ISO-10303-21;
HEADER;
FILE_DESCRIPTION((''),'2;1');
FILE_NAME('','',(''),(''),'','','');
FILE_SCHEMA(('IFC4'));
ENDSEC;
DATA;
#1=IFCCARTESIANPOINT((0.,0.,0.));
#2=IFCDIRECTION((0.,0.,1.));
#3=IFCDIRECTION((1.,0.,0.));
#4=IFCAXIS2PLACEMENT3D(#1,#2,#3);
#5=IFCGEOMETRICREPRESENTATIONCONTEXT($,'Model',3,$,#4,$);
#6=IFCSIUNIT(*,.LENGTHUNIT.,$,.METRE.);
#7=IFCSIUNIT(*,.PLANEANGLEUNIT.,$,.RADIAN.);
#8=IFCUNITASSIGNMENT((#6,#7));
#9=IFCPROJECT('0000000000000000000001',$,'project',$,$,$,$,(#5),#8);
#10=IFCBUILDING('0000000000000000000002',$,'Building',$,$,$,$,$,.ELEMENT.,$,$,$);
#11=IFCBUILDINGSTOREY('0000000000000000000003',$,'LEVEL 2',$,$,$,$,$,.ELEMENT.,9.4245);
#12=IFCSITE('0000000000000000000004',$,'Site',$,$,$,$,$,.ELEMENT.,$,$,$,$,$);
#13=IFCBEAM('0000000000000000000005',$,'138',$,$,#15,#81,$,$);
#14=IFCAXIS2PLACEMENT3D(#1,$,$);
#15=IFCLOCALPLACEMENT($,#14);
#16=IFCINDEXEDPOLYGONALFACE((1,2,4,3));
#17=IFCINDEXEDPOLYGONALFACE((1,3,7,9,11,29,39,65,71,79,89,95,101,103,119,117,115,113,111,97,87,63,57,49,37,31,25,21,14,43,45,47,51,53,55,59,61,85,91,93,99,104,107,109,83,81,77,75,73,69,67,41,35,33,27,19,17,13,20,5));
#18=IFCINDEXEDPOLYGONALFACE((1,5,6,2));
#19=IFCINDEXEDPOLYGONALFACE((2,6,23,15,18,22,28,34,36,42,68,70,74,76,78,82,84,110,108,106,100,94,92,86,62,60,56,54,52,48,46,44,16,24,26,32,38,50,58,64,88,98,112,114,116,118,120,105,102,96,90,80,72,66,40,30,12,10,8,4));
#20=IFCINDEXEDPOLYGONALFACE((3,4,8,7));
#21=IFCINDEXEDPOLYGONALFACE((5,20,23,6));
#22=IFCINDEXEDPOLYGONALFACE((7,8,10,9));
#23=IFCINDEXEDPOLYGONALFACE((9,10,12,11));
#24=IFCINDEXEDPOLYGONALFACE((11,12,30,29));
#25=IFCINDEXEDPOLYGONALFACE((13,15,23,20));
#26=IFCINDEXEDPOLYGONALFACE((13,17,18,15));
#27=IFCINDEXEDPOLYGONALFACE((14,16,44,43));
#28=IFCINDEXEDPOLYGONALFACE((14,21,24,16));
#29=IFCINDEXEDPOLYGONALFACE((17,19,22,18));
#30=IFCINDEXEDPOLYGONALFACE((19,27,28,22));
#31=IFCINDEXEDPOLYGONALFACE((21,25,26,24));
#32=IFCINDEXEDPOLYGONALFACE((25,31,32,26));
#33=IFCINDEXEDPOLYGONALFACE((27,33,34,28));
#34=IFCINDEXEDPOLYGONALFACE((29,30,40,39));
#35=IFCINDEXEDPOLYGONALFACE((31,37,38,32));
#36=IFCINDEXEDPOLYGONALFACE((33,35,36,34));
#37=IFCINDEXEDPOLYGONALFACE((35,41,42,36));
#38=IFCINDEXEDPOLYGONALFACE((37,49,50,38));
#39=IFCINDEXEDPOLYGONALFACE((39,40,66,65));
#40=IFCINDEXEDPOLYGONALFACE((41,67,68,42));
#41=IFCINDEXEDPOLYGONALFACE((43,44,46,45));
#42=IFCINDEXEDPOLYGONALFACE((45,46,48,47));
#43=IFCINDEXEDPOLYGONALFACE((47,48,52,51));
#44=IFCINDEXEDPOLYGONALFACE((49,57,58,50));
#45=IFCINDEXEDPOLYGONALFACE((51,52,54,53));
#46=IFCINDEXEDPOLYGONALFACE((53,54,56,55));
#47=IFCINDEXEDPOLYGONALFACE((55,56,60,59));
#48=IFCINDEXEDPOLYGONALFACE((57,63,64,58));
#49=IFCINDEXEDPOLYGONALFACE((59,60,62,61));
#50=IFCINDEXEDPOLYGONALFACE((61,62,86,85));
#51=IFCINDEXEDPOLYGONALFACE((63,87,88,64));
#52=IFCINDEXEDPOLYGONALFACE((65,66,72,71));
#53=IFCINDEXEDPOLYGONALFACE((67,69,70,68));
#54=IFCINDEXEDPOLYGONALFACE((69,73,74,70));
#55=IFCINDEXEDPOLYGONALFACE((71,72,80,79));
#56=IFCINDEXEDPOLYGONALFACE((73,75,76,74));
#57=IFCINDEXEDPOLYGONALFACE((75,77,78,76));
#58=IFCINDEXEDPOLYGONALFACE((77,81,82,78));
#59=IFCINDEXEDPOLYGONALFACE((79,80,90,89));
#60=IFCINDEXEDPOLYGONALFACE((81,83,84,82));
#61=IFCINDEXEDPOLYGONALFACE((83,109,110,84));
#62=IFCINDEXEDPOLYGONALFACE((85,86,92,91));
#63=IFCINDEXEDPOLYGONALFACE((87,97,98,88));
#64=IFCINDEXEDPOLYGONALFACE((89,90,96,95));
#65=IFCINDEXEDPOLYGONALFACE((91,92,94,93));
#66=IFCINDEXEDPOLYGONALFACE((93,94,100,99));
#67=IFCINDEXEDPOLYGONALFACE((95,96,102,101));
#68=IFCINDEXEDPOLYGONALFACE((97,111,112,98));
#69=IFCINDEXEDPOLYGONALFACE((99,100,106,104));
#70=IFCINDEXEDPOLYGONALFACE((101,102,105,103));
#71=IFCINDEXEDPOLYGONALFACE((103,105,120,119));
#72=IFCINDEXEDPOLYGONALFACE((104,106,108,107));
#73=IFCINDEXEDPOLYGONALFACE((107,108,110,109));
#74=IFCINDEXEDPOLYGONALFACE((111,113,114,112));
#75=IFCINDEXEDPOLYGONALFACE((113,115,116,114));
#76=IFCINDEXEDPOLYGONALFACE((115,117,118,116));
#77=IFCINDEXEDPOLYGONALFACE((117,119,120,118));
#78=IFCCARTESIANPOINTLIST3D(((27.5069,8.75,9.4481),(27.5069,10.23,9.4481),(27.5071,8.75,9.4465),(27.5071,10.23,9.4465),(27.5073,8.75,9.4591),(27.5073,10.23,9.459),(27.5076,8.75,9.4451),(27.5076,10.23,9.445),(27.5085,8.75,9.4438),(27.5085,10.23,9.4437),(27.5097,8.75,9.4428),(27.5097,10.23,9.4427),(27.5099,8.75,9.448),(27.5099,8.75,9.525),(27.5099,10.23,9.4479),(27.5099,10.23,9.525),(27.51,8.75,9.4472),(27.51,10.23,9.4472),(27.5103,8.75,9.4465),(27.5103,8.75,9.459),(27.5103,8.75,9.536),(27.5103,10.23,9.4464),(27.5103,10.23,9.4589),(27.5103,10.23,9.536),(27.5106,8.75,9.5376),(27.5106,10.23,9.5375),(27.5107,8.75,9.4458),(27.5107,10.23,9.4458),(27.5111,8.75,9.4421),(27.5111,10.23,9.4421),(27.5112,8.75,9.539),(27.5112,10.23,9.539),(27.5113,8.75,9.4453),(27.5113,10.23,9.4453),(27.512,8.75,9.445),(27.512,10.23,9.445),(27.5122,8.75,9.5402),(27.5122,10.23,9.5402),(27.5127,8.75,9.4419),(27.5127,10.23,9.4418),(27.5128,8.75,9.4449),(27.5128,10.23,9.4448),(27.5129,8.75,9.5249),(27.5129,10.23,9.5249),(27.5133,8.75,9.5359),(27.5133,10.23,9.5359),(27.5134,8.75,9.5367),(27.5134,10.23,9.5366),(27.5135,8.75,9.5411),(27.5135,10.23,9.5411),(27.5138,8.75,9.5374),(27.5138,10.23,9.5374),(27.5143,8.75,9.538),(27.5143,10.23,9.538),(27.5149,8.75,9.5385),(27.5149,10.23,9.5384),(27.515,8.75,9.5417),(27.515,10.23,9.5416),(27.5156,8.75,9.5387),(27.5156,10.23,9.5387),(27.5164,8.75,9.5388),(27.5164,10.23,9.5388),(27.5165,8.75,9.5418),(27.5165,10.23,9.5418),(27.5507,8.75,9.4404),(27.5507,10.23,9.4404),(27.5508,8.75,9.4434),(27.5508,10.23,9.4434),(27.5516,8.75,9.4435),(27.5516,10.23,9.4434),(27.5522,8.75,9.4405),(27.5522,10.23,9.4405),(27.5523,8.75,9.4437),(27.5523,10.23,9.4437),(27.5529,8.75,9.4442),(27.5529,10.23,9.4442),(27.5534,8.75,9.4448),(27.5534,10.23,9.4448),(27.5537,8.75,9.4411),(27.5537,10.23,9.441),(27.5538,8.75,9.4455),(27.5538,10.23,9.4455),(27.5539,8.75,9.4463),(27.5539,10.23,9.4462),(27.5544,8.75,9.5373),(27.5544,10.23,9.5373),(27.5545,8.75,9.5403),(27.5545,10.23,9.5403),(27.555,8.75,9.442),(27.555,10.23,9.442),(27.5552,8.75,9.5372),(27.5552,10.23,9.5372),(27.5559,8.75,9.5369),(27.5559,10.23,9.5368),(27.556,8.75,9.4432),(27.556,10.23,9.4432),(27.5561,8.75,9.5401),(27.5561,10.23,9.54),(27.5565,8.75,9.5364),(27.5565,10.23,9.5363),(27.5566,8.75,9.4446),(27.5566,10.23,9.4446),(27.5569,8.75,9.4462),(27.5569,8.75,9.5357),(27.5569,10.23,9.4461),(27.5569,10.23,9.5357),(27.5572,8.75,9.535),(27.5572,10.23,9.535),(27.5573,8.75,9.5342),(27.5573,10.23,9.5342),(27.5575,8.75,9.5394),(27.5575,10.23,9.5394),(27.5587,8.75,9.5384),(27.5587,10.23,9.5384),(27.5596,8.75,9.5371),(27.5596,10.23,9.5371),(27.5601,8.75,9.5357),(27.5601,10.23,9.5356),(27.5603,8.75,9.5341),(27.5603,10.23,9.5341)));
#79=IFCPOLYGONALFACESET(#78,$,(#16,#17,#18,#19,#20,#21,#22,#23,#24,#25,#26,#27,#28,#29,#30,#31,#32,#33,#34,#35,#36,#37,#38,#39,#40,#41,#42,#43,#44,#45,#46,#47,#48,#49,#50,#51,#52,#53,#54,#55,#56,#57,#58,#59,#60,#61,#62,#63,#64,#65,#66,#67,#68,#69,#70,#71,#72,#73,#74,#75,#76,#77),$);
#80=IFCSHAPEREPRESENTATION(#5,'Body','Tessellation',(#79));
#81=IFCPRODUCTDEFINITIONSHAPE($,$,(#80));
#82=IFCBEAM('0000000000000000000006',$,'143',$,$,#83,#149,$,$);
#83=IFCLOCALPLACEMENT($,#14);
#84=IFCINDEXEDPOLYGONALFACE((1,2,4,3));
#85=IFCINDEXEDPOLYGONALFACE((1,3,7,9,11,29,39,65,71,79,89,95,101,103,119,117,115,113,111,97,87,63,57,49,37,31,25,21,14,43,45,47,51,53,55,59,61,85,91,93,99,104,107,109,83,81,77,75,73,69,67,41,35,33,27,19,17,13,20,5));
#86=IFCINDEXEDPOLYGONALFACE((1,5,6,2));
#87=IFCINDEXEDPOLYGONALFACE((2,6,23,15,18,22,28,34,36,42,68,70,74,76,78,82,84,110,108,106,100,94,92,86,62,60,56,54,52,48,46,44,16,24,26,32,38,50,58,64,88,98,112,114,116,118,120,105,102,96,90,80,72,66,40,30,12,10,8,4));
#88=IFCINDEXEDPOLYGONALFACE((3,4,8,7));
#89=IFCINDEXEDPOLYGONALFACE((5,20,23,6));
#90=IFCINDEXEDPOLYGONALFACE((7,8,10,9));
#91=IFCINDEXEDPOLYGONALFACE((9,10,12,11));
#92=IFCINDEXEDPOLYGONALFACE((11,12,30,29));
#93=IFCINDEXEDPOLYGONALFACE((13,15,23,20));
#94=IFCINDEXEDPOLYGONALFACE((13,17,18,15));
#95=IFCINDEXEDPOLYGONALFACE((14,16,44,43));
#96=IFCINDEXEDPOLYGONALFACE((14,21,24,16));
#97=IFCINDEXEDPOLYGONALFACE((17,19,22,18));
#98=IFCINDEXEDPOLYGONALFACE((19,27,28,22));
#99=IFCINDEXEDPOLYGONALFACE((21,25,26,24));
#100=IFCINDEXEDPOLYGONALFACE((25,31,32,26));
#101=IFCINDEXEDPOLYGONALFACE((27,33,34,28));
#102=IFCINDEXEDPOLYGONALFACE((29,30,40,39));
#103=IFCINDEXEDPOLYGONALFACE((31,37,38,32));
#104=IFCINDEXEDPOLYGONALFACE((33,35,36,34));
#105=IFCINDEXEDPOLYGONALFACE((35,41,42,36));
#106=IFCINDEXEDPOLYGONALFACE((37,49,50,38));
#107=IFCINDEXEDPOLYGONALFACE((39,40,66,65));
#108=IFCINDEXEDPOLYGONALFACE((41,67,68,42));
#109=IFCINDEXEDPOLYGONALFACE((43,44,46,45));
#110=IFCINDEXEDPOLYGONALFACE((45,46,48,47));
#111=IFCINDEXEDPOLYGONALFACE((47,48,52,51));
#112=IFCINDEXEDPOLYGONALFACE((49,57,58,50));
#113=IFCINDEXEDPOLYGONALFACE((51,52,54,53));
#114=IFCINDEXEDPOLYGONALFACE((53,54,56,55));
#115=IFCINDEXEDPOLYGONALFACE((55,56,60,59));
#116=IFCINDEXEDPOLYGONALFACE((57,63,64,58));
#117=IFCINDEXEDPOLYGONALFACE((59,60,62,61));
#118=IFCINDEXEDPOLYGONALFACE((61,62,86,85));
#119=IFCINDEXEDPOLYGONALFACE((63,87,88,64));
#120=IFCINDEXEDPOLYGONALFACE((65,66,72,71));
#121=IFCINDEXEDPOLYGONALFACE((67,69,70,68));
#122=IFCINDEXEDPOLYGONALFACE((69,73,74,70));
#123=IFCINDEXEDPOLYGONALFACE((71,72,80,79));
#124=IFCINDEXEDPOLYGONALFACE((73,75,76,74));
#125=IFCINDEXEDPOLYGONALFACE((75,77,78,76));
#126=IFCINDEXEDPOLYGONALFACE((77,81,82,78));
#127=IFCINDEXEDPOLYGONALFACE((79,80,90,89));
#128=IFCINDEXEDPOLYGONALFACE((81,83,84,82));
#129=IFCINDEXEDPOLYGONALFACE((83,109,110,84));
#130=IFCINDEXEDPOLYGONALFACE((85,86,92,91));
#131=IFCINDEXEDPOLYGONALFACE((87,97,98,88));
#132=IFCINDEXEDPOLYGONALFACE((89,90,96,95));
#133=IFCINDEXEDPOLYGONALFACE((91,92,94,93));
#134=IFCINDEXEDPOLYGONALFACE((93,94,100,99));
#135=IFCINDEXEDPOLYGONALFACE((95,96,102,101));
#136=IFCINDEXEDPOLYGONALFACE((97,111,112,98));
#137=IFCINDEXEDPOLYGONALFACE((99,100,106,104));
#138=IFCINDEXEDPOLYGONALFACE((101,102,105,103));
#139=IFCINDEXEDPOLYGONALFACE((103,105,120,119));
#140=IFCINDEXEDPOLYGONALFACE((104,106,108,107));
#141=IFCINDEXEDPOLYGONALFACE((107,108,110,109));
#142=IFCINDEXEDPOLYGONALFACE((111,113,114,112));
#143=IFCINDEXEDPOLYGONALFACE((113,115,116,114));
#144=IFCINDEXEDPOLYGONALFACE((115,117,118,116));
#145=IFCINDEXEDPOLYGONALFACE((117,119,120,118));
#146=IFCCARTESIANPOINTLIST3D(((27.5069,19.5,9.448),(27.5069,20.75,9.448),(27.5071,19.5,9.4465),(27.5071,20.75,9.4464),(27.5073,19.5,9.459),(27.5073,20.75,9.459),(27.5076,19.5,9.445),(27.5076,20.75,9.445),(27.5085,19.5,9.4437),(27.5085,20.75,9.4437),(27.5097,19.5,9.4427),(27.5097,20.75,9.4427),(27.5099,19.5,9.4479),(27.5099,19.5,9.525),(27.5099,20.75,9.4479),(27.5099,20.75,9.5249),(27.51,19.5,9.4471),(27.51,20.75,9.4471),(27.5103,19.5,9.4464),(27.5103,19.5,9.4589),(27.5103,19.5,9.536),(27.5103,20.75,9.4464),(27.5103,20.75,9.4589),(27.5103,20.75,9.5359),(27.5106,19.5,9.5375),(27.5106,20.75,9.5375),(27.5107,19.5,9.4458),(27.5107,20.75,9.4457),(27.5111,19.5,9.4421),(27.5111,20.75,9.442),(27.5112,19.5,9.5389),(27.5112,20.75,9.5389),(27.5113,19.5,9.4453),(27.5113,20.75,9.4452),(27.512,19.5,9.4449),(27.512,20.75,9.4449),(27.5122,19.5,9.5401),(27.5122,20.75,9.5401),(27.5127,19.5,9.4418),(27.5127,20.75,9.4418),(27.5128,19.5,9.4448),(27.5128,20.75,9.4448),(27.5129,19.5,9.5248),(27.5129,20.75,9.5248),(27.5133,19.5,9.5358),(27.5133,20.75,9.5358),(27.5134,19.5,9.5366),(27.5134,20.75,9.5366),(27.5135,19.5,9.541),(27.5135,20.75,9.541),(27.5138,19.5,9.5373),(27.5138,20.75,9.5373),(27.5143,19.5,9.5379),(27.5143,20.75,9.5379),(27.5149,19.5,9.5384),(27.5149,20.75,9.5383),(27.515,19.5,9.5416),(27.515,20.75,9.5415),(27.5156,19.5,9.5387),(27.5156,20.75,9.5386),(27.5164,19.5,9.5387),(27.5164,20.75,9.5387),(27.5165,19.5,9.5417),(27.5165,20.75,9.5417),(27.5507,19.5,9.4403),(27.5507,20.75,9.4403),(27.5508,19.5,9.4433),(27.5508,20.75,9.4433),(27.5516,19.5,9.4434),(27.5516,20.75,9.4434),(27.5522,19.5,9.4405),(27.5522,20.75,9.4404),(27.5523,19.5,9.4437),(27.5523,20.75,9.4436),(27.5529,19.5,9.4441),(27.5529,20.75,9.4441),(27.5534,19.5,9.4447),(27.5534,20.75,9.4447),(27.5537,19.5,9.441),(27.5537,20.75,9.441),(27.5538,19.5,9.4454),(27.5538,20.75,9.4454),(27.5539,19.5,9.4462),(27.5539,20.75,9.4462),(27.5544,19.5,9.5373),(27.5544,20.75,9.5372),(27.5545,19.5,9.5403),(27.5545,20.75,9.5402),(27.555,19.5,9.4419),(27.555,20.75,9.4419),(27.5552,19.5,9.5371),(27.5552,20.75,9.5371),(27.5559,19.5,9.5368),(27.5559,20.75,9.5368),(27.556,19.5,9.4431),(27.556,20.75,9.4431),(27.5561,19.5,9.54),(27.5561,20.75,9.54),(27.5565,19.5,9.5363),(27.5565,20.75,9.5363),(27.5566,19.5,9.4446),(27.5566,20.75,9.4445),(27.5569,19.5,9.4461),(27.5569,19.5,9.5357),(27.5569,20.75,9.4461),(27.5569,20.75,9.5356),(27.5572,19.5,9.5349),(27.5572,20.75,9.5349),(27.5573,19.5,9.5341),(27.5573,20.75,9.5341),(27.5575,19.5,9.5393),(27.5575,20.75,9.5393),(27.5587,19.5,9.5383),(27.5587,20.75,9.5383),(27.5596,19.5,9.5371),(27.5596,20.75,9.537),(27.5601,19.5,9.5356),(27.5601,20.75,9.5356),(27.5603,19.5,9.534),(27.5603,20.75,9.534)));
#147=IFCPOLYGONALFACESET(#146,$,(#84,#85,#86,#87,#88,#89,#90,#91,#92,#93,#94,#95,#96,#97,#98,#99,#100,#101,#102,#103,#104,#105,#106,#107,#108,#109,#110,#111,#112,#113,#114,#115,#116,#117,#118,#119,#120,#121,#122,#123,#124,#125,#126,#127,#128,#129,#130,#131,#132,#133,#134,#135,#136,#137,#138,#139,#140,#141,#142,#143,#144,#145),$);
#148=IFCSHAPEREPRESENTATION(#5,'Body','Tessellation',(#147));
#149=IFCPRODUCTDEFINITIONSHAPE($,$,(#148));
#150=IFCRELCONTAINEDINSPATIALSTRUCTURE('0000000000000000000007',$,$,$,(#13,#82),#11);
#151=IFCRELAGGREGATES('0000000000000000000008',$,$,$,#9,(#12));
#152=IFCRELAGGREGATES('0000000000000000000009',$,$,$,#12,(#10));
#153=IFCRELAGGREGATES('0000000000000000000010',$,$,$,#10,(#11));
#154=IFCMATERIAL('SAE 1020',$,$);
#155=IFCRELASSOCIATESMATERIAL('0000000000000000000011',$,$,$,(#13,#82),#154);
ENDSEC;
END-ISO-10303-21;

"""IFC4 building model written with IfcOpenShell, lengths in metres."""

from ifc_helpers import new_model, si_unit, frame, origin_with_axes, origin_2d_with_axis, place, context, project, spatial, c_section, extrude, material, material_profile, profile_set, profile_usage, element, save


model = new_model("IFC4")

# Units and contexts
model_context = context("Model", 3, world=origin_with_axes())
ifc_project = project(units=[si_unit("LENGTHUNIT", "METRE"), si_unit("PLANEANGLEUNIT", "RADIAN")], contexts=[model_context])

# Site, building, storey
site = spatial("IfcSite", under=ifc_project, Name="Site", CompositionType="ELEMENT")
building = spatial("IfcBuilding", under=site, Name="Building", CompositionType="ELEMENT")
storey = spatial("IfcBuildingStorey", under=building, Name="LEVEL 2", CompositionType="ELEMENT", Elevation=9.4245)

# Beams
ifc_material = material(Name="SAE 1020")
ifc_material_profile_1 = material_profile(ifc_material, c_section(Depth=0.1, Width=0.05, WallThickness=0.003, Girth=0.017, InternalFilletRadius=0.003, at=origin_2d_with_axis()))
ifc_profile_set_1 = profile_set([ifc_material_profile_1])
ifc_profile_usage_1 = profile_usage(ifc_profile_set_1, cardinal=10)
beam_1_placement = place(None, frame((27.5336, 8.75, 9.4911), z_axis=(0.0, 1.0, -0.00003), x_axis=(-0.999256, 0.000001, 0.038562)))
element("IfcBeam", 1, at=beam_1_placement, inside=storey, material=ifc_profile_usage_1, Name="138", context=model_context, shape_type="SweptSolid", body=[
    extrude(c_section(Depth=0.1, Width=0.05, WallThickness=0.003, Girth=0.017, InternalFilletRadius=0.003, at=origin_2d_with_axis()), origin_with_axes(), (0.0, 0.0, 1.0), 1.48),
])
ifc_material_profile_2 = material_profile(ifc_material, c_section(Depth=0.1, Width=0.05, WallThickness=0.003, Girth=0.017, InternalFilletRadius=0.003, at=origin_2d_with_axis()))
ifc_profile_set_2 = profile_set([ifc_material_profile_2])
ifc_profile_usage_2 = profile_usage(ifc_profile_set_2, cardinal=10)
beam_2_placement = place(None, frame((27.5336, 19.5, 9.491), z_axis=(0.0, 1.0, -0.00003), x_axis=(-0.999256, 0.000001, 0.038562)))
element("IfcBeam", 2, at=beam_2_placement, inside=storey, material=ifc_profile_usage_2, Name="143", context=model_context, shape_type="SweptSolid", body=[
    extrude(c_section(Depth=0.1, Width=0.05, WallThickness=0.003, Girth=0.017, InternalFilletRadius=0.003, at=origin_2d_with_axis()), origin_with_axes(), (0.0, 0.0, 1.0), 1.25),
])

save(model, "model.ifc")
